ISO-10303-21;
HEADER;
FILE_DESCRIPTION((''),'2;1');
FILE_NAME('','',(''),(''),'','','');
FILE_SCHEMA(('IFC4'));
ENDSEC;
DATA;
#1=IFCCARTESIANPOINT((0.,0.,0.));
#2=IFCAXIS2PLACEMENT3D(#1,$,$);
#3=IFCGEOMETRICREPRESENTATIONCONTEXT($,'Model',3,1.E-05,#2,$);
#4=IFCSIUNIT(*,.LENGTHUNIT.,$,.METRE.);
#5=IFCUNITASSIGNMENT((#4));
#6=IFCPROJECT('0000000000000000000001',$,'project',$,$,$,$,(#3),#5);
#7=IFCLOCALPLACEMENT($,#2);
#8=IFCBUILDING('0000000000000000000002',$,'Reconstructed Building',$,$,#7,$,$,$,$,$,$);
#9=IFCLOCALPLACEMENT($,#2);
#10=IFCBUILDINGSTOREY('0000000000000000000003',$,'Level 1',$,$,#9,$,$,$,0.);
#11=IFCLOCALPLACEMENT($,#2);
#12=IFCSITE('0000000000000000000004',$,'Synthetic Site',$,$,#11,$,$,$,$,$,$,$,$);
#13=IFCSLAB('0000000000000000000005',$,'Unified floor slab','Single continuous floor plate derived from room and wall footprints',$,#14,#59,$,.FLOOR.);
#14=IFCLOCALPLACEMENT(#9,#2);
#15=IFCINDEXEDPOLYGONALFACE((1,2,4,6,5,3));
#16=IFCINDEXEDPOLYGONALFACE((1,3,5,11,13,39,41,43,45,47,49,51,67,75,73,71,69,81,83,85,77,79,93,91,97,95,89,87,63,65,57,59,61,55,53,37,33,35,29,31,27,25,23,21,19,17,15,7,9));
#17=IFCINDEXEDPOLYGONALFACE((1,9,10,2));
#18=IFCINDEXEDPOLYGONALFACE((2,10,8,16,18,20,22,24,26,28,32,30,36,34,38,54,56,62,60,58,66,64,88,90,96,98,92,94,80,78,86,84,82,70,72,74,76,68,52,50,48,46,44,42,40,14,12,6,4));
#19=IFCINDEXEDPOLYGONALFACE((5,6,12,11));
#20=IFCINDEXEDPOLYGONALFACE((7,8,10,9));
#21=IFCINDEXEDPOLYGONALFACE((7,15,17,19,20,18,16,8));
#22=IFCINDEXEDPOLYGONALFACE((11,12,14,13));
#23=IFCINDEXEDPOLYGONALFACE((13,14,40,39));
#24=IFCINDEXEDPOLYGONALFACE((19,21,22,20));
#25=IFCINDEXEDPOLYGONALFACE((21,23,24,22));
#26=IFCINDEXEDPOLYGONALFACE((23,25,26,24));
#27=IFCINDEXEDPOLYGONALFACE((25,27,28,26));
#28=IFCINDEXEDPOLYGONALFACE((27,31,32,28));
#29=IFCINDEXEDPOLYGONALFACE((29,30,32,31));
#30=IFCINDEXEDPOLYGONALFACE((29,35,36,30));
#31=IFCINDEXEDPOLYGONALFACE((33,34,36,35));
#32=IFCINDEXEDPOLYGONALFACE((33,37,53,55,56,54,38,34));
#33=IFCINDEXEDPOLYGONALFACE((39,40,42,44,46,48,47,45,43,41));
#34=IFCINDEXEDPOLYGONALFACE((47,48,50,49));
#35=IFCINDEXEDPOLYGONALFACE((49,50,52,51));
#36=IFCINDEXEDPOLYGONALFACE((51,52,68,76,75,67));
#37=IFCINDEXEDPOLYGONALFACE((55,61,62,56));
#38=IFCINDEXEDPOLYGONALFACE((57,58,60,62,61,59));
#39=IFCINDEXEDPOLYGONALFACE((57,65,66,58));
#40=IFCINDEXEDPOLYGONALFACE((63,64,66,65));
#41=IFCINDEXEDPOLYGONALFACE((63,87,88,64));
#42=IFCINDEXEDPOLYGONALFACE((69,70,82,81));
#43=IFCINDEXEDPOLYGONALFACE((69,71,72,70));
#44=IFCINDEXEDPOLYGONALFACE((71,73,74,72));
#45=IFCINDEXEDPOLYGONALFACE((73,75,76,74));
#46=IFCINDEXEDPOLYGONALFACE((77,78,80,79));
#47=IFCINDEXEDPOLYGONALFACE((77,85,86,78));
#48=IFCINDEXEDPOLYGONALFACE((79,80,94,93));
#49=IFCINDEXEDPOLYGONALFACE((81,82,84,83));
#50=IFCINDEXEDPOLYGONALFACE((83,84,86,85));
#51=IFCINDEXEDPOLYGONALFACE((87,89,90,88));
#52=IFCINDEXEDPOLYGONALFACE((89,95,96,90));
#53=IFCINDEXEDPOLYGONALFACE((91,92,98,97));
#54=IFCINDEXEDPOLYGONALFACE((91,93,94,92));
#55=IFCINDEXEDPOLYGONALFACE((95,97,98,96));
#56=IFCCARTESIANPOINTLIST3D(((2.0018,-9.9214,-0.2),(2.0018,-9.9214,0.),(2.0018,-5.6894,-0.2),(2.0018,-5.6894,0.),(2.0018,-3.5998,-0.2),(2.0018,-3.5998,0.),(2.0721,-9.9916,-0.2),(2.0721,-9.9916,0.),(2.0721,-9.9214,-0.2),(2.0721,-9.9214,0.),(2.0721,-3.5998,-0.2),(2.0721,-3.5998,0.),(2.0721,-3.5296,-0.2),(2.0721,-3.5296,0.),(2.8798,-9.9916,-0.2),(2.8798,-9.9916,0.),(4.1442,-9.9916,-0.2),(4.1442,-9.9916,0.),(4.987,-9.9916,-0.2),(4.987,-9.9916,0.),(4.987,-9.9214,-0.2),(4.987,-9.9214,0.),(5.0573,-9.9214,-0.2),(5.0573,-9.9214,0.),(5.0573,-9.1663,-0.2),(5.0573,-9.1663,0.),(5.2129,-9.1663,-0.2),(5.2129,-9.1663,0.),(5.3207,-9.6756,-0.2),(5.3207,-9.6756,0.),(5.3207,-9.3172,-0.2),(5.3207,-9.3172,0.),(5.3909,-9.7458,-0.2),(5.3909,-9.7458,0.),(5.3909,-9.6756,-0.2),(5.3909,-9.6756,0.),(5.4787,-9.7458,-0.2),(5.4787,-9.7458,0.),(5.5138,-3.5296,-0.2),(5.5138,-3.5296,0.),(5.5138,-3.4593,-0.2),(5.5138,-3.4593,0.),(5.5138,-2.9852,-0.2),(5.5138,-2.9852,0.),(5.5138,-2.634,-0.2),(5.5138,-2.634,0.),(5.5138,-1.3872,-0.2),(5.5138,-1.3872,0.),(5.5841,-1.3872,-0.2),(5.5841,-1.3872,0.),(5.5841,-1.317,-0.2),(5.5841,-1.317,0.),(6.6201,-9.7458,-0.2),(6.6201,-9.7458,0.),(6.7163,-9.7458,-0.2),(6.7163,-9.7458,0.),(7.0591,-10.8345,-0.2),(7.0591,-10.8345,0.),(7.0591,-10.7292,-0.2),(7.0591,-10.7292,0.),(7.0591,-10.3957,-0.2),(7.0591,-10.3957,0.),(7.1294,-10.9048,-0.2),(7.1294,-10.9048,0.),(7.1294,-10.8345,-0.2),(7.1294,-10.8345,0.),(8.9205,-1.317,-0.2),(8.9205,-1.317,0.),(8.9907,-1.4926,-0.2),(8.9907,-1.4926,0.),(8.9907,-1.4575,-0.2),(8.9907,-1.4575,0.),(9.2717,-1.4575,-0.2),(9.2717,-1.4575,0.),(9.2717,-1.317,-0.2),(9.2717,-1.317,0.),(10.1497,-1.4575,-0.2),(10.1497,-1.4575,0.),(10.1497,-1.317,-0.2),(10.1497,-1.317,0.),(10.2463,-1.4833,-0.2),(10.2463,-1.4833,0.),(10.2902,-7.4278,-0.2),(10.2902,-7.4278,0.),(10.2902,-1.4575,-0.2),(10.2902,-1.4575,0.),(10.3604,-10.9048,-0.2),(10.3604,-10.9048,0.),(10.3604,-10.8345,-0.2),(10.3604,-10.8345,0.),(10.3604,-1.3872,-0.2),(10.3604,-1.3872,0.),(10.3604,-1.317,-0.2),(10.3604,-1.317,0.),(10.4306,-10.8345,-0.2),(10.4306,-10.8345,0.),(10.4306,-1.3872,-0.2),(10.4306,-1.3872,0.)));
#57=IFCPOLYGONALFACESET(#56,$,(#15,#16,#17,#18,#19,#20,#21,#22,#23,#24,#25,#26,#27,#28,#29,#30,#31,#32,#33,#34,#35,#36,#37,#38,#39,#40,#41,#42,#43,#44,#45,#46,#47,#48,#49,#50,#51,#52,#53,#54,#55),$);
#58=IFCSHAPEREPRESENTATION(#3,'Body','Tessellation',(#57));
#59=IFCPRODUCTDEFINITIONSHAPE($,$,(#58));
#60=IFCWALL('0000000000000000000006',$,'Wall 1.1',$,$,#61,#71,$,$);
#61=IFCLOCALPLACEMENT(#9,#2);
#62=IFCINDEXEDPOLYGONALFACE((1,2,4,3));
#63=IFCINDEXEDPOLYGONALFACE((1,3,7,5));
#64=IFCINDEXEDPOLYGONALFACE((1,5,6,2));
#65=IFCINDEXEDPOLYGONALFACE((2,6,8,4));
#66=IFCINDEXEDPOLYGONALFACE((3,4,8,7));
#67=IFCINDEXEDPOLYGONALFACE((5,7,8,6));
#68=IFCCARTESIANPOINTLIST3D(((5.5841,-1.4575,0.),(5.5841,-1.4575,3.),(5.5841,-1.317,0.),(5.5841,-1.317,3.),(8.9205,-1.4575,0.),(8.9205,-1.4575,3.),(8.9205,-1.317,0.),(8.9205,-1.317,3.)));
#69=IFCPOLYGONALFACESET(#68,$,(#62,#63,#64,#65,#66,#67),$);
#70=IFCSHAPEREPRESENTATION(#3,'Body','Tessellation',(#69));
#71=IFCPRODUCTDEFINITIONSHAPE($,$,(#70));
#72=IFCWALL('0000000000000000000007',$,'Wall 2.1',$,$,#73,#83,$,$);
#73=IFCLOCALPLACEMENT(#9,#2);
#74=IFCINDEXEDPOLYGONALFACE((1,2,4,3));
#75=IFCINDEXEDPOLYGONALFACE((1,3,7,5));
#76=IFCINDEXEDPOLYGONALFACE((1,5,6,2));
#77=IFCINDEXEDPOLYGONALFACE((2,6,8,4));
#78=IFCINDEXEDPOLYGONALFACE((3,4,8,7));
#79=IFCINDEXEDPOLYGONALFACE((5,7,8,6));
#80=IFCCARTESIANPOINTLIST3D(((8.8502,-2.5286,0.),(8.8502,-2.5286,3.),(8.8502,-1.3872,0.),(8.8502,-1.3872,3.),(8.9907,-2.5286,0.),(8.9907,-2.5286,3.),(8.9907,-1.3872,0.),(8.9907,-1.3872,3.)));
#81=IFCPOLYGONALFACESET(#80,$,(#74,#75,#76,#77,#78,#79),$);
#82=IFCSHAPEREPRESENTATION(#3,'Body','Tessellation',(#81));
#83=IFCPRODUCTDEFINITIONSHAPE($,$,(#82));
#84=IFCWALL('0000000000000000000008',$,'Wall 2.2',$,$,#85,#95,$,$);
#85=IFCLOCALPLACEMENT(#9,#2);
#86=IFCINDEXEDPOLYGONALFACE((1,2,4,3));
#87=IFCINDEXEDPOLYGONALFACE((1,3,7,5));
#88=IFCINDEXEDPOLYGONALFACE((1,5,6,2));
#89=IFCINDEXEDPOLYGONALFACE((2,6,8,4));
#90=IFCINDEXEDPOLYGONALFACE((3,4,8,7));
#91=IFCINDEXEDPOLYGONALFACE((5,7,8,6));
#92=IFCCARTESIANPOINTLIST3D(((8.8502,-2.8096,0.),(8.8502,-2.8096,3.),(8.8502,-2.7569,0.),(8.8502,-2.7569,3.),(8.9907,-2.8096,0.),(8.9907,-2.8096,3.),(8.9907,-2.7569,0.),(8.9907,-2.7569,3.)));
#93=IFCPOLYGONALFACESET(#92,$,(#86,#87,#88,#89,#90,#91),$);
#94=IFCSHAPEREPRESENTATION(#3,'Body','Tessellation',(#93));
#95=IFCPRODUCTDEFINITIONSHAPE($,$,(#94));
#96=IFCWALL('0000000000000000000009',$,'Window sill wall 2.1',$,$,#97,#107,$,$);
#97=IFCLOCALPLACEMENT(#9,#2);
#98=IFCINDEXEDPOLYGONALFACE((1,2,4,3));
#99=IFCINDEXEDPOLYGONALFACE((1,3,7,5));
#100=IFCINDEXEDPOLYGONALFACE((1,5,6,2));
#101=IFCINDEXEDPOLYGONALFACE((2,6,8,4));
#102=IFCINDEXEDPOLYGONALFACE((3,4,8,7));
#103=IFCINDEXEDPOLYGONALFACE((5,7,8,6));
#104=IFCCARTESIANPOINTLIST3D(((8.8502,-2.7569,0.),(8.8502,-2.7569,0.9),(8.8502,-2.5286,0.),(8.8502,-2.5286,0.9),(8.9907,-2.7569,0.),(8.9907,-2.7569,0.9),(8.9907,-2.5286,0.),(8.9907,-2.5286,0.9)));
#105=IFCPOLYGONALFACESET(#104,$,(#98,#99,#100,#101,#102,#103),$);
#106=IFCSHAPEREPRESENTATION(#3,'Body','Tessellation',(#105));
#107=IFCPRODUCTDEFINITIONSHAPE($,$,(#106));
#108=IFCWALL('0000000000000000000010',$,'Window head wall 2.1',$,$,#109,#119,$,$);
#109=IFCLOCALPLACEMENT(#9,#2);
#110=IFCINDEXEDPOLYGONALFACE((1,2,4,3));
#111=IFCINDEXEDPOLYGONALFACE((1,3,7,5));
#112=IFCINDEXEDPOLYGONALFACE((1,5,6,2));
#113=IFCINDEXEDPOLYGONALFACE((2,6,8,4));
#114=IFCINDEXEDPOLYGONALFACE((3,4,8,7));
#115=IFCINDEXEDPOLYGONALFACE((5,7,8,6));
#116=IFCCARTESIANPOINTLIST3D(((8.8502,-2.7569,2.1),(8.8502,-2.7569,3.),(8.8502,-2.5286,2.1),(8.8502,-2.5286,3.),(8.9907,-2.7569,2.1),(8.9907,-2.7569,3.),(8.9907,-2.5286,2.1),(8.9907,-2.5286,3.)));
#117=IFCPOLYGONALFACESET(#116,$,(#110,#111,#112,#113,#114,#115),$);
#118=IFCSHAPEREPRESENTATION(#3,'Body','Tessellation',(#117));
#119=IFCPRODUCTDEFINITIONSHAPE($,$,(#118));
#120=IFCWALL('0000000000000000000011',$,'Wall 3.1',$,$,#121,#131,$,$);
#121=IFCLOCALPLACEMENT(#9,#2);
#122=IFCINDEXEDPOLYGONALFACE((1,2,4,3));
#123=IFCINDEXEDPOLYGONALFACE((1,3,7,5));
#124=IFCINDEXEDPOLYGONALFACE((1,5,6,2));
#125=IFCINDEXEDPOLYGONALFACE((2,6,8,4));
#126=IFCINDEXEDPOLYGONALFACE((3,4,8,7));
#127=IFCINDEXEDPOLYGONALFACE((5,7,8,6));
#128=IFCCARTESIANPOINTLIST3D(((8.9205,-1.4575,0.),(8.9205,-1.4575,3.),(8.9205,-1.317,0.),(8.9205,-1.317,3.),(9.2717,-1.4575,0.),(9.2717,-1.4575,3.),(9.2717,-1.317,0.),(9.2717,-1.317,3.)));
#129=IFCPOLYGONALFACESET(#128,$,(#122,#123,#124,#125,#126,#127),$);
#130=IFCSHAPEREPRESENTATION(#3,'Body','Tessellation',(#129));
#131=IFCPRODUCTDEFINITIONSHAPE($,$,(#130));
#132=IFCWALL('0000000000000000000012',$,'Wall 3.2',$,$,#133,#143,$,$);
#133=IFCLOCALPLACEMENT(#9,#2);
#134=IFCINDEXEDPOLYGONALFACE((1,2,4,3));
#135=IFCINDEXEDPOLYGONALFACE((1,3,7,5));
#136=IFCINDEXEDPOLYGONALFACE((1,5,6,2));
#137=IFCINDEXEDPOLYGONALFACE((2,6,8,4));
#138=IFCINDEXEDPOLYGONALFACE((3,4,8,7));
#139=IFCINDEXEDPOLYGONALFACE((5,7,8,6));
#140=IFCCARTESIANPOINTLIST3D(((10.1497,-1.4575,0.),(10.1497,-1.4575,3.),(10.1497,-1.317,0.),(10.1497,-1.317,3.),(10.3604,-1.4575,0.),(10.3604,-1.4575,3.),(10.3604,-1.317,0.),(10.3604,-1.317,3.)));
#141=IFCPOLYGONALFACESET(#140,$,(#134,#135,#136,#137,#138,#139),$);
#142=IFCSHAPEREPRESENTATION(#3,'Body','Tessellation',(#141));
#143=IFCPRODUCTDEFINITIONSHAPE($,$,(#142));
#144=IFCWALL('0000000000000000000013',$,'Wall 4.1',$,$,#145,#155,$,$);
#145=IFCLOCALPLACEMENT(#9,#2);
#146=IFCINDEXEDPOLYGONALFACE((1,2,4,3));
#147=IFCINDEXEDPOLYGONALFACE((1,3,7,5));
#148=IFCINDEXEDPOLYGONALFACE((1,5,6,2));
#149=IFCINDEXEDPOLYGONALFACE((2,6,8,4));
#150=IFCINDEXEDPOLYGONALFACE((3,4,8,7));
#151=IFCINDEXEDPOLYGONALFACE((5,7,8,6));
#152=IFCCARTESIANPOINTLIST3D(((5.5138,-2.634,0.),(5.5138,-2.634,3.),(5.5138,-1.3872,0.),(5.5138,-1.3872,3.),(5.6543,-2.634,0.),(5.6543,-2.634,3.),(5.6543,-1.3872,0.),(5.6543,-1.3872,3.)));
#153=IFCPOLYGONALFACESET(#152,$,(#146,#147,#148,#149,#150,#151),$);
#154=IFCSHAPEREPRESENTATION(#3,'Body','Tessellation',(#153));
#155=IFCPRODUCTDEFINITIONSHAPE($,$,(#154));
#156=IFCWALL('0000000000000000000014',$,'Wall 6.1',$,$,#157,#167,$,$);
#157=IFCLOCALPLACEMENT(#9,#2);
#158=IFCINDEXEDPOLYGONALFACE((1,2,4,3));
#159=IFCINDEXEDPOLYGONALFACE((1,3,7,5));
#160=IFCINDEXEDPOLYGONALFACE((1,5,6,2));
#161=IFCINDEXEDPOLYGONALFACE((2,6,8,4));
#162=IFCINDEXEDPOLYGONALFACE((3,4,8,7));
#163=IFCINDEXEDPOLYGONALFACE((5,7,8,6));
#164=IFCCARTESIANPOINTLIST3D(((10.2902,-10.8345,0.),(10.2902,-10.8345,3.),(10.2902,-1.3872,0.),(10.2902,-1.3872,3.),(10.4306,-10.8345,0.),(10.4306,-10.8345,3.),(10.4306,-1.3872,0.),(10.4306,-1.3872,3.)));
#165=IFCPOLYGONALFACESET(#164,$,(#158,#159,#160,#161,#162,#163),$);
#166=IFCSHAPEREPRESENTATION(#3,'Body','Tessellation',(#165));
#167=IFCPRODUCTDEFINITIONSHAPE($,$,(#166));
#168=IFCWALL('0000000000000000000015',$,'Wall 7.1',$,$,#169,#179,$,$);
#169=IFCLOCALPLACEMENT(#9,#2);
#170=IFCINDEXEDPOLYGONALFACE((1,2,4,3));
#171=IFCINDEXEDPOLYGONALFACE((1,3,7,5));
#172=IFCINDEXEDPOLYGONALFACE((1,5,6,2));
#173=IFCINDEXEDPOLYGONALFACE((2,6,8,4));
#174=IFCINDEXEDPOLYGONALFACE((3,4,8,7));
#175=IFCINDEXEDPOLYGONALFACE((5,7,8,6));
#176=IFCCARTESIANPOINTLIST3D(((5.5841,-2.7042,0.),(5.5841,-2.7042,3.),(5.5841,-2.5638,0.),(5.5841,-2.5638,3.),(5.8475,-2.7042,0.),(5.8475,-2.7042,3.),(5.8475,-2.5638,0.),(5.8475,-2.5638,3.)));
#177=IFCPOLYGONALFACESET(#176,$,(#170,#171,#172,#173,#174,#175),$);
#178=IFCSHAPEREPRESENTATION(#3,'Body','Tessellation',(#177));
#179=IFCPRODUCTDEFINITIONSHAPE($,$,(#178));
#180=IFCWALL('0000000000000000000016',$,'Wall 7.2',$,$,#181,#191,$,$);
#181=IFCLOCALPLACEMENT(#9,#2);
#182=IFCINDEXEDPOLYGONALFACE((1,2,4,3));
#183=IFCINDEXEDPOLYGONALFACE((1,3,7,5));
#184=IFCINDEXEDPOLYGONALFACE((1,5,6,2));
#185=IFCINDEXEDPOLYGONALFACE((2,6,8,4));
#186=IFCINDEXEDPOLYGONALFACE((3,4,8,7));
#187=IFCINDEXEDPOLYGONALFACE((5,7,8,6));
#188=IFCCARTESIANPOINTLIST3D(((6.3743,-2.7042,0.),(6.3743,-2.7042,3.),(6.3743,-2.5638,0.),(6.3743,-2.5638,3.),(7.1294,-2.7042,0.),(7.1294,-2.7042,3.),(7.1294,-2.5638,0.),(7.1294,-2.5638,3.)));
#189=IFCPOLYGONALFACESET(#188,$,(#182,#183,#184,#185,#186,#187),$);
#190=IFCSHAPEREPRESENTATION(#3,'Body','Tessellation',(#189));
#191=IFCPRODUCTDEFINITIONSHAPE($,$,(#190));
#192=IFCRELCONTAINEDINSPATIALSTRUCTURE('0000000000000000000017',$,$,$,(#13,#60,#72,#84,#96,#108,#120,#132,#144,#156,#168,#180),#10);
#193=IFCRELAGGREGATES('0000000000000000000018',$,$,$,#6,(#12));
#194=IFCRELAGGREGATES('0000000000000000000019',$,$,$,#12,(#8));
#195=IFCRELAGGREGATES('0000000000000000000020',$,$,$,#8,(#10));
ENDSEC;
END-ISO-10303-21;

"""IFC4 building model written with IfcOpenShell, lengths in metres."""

from ifc_helpers import new_model, si_unit, frame, origin, place, context, project, spatial, polyline, outline, extrude, element, save


model = new_model("IFC4")

# Units and contexts
model_context = context("Model", 3, precision=1e-05, world=origin())
ifc_project = project(units=[si_unit("LENGTHUNIT", "METRE")], contexts=[model_context])

# Site, building, storey
site_placement = place(None, origin())
site = spatial("IfcSite", under=ifc_project, at=site_placement, Name="Synthetic Site")
building_placement = place(None, origin())
building = spatial("IfcBuilding", under=site, at=building_placement, Name="Reconstructed Building")
storey_placement = place(None, origin())
storey = spatial("IfcBuildingStorey", under=building, at=storey_placement, Name="Level 1", Elevation=0.0)

# Slab
slab_placement = place(None, origin())
element("IfcSlab", 1, at=slab_placement, inside=storey, Name="Unified floor slab", Description="Single continuous floor plate derived from room and wall footprints", PredefinedType="FLOOR", context=model_context, shape_type="SweptSolid", body=[
    extrude(outline(polyline([(5.3909, -9.6756), (5.3207, -9.6756), (5.3207, -9.3172), (5.2129, -9.1663), (5.0573, -9.1663), (5.0573, -9.9214), (4.987, -9.9214), (4.987, -9.9916), (4.1442, -9.9916), (2.8798, -9.9916), (2.0721, -9.9916), (2.0721, -9.9214), (2.0018, -9.9214), (2.0018, -5.6894), (2.0018, -3.5998), (2.0721, -3.5998), (2.0721, -3.5296), (5.5138, -3.5296), (5.5138, -3.4593), (5.5138, -2.9852), (5.5138, -2.634), (5.5138, -1.3872), (5.5841, -1.3872), (5.5841, -1.317), (8.9205, -1.317), (9.2717, -1.317), (9.2717, -1.4575), (8.9907, -1.4575), (8.9907, -1.4926), (10.2463, -1.4833), (10.2902, -7.4278), (10.2902, -1.4575), (10.1497, -1.4575), (10.1497, -1.317), (10.3604, -1.317), (10.3604, -1.3872), (10.4306, -1.3872), (10.4306, -10.8345), (10.3604, -10.8345), (10.3604, -10.9048), (7.1294, -10.9048), (7.1294, -10.8345), (7.0591, -10.8345), (7.0591, -10.7292), (7.0591, -10.3957), (6.7163, -9.7458), (6.6201, -9.7458), (5.4787, -9.7458), (5.3909, -9.7458), (5.3909, -9.6756)])), frame((0.0, 0.0, -0.2), z_axis=(0.0, 0.0, 1.0)), (0.0, 0.0, 1.0), 0.2),
])

# Walls
wall_1_placement = place(None, origin())
element("IfcWall", 2, at=wall_1_placement, inside=storey, Name="Wall 1.1", context=model_context, shape_type="SweptSolid", body=[
    extrude(outline(polyline([(8.9205, -1.317), (5.5841, -1.317), (5.5841, -1.4575), (8.9205, -1.4575), (8.9205, -1.317)])), frame((0.0, 0.0, 0.0), z_axis=(0.0, 0.0, 1.0)), (0.0, 0.0, 1.0), 3.0),
])
wall_2_placement = place(None, origin())
element("IfcWall", 3, at=wall_2_placement, inside=storey, Name="Wall 2.1", context=model_context, shape_type="SweptSolid", body=[
    extrude(outline(polyline([(8.8502, -1.3872), (8.8502, -2.5286), (8.9907, -2.5286), (8.9907, -1.3872), (8.8502, -1.3872)])), frame((0.0, 0.0, 0.0), z_axis=(0.0, 0.0, 1.0)), (0.0, 0.0, 1.0), 3.0),
])
wall_3_placement = place(None, origin())
element("IfcWall", 4, at=wall_3_placement, inside=storey, Name="Wall 2.2", context=model_context, shape_type="SweptSolid", body=[
    extrude(outline(polyline([(8.8502, -2.7569), (8.8502, -2.8096), (8.9907, -2.8096), (8.9907, -2.7569), (8.8502, -2.7569)])), frame((0.0, 0.0, 0.0), z_axis=(0.0, 0.0, 1.0)), (0.0, 0.0, 1.0), 3.0),
])
wall_4_placement = place(None, origin())
element("IfcWall", 5, at=wall_4_placement, inside=storey, Name="Window sill wall 2.1", context=model_context, shape_type="SweptSolid", body=[
    extrude(outline(polyline([(8.8502, -2.5286), (8.8502, -2.7569), (8.9907, -2.7569), (8.9907, -2.5286), (8.8502, -2.5286)])), frame((0.0, 0.0, 0.0), z_axis=(0.0, 0.0, 1.0)), (0.0, 0.0, 1.0), 0.9),
])
wall_5_placement = place(None, origin())
element("IfcWall", 6, at=wall_5_placement, inside=storey, Name="Window head wall 2.1", context=model_context, shape_type="SweptSolid", body=[
    extrude(outline(polyline([(8.8502, -2.5286), (8.8502, -2.7569), (8.9907, -2.7569), (8.9907, -2.5286), (8.8502, -2.5286)])), frame((0.0, 0.0, 2.1), z_axis=(0.0, 0.0, 1.0)), (0.0, 0.0, 1.0), 0.9),
])
wall_6_placement = place(None, origin())
element("IfcWall", 7, at=wall_6_placement, inside=storey, Name="Wall 3.1", context=model_context, shape_type="SweptSolid", body=[
    extrude(outline(polyline([(8.9205, -1.4575), (9.2717, -1.4575), (9.2717, -1.317), (8.9205, -1.317), (8.9205, -1.4575)])), frame((0.0, 0.0, 0.0), z_axis=(0.0, 0.0, 1.0)), (0.0, 0.0, 1.0), 3.0),
])
wall_7_placement = place(None, origin())
element("IfcWall", 8, at=wall_7_placement, inside=storey, Name="Wall 3.2", context=model_context, shape_type="SweptSolid", body=[
    extrude(outline(polyline([(10.1497, -1.4575), (10.3604, -1.4575), (10.3604, -1.317), (10.1497, -1.317), (10.1497, -1.4575)])), frame((0.0, 0.0, 0.0), z_axis=(0.0, 0.0, 1.0)), (0.0, 0.0, 1.0), 3.0),
])
wall_8_placement = place(None, origin())
element("IfcWall", 9, at=wall_8_placement, inside=storey, Name="Wall 4.1", context=model_context, shape_type="SweptSolid", body=[
    extrude(outline(polyline([(5.5138, -1.3872), (5.5138, -2.634), (5.6543, -2.634), (5.6543, -1.3872), (5.5138, -1.3872)])), frame((0.0, 0.0, 0.0), z_axis=(0.0, 0.0, 1.0)), (0.0, 0.0, 1.0), 3.0),
])
wall_9_placement = place(None, origin())
element("IfcWall", 10, at=wall_9_placement, inside=storey, Name="Wall 6.1", context=model_context, shape_type="SweptSolid", body=[
    extrude(outline(polyline([(10.2902, -1.3872), (10.2902, -10.8345), (10.4306, -10.8345), (10.4306, -1.3872), (10.2902, -1.3872)])), frame((0.0, 0.0, 0.0), z_axis=(0.0, 0.0, 1.0)), (0.0, 0.0, 1.0), 3.0),
])
wall_10_placement = place(None, origin())
element("IfcWall", 11, at=wall_10_placement, inside=storey, Name="Wall 7.1", context=model_context, shape_type="SweptSolid", body=[
    extrude(outline(polyline([(5.5841, -2.7042), (5.8475, -2.7042), (5.8475, -2.5638), (5.5841, -2.5638), (5.5841, -2.7042)])), frame((0.0, 0.0, 0.0), z_axis=(0.0, 0.0, 1.0)), (0.0, 0.0, 1.0), 3.0),
])
wall_11_placement = place(None, origin())
element("IfcWall", 12, at=wall_11_placement, inside=storey, Name="Wall 7.2", context=model_context, shape_type="SweptSolid", body=[
    extrude(outline(polyline([(6.3743, -2.7042), (7.1294, -2.7042), (7.1294, -2.5638), (6.3743, -2.5638), (6.3743, -2.7042)])), frame((0.0, 0.0, 0.0), z_axis=(0.0, 0.0, 1.0)), (0.0, 0.0, 1.0), 3.0),
])

save(model, "model.ifc")
